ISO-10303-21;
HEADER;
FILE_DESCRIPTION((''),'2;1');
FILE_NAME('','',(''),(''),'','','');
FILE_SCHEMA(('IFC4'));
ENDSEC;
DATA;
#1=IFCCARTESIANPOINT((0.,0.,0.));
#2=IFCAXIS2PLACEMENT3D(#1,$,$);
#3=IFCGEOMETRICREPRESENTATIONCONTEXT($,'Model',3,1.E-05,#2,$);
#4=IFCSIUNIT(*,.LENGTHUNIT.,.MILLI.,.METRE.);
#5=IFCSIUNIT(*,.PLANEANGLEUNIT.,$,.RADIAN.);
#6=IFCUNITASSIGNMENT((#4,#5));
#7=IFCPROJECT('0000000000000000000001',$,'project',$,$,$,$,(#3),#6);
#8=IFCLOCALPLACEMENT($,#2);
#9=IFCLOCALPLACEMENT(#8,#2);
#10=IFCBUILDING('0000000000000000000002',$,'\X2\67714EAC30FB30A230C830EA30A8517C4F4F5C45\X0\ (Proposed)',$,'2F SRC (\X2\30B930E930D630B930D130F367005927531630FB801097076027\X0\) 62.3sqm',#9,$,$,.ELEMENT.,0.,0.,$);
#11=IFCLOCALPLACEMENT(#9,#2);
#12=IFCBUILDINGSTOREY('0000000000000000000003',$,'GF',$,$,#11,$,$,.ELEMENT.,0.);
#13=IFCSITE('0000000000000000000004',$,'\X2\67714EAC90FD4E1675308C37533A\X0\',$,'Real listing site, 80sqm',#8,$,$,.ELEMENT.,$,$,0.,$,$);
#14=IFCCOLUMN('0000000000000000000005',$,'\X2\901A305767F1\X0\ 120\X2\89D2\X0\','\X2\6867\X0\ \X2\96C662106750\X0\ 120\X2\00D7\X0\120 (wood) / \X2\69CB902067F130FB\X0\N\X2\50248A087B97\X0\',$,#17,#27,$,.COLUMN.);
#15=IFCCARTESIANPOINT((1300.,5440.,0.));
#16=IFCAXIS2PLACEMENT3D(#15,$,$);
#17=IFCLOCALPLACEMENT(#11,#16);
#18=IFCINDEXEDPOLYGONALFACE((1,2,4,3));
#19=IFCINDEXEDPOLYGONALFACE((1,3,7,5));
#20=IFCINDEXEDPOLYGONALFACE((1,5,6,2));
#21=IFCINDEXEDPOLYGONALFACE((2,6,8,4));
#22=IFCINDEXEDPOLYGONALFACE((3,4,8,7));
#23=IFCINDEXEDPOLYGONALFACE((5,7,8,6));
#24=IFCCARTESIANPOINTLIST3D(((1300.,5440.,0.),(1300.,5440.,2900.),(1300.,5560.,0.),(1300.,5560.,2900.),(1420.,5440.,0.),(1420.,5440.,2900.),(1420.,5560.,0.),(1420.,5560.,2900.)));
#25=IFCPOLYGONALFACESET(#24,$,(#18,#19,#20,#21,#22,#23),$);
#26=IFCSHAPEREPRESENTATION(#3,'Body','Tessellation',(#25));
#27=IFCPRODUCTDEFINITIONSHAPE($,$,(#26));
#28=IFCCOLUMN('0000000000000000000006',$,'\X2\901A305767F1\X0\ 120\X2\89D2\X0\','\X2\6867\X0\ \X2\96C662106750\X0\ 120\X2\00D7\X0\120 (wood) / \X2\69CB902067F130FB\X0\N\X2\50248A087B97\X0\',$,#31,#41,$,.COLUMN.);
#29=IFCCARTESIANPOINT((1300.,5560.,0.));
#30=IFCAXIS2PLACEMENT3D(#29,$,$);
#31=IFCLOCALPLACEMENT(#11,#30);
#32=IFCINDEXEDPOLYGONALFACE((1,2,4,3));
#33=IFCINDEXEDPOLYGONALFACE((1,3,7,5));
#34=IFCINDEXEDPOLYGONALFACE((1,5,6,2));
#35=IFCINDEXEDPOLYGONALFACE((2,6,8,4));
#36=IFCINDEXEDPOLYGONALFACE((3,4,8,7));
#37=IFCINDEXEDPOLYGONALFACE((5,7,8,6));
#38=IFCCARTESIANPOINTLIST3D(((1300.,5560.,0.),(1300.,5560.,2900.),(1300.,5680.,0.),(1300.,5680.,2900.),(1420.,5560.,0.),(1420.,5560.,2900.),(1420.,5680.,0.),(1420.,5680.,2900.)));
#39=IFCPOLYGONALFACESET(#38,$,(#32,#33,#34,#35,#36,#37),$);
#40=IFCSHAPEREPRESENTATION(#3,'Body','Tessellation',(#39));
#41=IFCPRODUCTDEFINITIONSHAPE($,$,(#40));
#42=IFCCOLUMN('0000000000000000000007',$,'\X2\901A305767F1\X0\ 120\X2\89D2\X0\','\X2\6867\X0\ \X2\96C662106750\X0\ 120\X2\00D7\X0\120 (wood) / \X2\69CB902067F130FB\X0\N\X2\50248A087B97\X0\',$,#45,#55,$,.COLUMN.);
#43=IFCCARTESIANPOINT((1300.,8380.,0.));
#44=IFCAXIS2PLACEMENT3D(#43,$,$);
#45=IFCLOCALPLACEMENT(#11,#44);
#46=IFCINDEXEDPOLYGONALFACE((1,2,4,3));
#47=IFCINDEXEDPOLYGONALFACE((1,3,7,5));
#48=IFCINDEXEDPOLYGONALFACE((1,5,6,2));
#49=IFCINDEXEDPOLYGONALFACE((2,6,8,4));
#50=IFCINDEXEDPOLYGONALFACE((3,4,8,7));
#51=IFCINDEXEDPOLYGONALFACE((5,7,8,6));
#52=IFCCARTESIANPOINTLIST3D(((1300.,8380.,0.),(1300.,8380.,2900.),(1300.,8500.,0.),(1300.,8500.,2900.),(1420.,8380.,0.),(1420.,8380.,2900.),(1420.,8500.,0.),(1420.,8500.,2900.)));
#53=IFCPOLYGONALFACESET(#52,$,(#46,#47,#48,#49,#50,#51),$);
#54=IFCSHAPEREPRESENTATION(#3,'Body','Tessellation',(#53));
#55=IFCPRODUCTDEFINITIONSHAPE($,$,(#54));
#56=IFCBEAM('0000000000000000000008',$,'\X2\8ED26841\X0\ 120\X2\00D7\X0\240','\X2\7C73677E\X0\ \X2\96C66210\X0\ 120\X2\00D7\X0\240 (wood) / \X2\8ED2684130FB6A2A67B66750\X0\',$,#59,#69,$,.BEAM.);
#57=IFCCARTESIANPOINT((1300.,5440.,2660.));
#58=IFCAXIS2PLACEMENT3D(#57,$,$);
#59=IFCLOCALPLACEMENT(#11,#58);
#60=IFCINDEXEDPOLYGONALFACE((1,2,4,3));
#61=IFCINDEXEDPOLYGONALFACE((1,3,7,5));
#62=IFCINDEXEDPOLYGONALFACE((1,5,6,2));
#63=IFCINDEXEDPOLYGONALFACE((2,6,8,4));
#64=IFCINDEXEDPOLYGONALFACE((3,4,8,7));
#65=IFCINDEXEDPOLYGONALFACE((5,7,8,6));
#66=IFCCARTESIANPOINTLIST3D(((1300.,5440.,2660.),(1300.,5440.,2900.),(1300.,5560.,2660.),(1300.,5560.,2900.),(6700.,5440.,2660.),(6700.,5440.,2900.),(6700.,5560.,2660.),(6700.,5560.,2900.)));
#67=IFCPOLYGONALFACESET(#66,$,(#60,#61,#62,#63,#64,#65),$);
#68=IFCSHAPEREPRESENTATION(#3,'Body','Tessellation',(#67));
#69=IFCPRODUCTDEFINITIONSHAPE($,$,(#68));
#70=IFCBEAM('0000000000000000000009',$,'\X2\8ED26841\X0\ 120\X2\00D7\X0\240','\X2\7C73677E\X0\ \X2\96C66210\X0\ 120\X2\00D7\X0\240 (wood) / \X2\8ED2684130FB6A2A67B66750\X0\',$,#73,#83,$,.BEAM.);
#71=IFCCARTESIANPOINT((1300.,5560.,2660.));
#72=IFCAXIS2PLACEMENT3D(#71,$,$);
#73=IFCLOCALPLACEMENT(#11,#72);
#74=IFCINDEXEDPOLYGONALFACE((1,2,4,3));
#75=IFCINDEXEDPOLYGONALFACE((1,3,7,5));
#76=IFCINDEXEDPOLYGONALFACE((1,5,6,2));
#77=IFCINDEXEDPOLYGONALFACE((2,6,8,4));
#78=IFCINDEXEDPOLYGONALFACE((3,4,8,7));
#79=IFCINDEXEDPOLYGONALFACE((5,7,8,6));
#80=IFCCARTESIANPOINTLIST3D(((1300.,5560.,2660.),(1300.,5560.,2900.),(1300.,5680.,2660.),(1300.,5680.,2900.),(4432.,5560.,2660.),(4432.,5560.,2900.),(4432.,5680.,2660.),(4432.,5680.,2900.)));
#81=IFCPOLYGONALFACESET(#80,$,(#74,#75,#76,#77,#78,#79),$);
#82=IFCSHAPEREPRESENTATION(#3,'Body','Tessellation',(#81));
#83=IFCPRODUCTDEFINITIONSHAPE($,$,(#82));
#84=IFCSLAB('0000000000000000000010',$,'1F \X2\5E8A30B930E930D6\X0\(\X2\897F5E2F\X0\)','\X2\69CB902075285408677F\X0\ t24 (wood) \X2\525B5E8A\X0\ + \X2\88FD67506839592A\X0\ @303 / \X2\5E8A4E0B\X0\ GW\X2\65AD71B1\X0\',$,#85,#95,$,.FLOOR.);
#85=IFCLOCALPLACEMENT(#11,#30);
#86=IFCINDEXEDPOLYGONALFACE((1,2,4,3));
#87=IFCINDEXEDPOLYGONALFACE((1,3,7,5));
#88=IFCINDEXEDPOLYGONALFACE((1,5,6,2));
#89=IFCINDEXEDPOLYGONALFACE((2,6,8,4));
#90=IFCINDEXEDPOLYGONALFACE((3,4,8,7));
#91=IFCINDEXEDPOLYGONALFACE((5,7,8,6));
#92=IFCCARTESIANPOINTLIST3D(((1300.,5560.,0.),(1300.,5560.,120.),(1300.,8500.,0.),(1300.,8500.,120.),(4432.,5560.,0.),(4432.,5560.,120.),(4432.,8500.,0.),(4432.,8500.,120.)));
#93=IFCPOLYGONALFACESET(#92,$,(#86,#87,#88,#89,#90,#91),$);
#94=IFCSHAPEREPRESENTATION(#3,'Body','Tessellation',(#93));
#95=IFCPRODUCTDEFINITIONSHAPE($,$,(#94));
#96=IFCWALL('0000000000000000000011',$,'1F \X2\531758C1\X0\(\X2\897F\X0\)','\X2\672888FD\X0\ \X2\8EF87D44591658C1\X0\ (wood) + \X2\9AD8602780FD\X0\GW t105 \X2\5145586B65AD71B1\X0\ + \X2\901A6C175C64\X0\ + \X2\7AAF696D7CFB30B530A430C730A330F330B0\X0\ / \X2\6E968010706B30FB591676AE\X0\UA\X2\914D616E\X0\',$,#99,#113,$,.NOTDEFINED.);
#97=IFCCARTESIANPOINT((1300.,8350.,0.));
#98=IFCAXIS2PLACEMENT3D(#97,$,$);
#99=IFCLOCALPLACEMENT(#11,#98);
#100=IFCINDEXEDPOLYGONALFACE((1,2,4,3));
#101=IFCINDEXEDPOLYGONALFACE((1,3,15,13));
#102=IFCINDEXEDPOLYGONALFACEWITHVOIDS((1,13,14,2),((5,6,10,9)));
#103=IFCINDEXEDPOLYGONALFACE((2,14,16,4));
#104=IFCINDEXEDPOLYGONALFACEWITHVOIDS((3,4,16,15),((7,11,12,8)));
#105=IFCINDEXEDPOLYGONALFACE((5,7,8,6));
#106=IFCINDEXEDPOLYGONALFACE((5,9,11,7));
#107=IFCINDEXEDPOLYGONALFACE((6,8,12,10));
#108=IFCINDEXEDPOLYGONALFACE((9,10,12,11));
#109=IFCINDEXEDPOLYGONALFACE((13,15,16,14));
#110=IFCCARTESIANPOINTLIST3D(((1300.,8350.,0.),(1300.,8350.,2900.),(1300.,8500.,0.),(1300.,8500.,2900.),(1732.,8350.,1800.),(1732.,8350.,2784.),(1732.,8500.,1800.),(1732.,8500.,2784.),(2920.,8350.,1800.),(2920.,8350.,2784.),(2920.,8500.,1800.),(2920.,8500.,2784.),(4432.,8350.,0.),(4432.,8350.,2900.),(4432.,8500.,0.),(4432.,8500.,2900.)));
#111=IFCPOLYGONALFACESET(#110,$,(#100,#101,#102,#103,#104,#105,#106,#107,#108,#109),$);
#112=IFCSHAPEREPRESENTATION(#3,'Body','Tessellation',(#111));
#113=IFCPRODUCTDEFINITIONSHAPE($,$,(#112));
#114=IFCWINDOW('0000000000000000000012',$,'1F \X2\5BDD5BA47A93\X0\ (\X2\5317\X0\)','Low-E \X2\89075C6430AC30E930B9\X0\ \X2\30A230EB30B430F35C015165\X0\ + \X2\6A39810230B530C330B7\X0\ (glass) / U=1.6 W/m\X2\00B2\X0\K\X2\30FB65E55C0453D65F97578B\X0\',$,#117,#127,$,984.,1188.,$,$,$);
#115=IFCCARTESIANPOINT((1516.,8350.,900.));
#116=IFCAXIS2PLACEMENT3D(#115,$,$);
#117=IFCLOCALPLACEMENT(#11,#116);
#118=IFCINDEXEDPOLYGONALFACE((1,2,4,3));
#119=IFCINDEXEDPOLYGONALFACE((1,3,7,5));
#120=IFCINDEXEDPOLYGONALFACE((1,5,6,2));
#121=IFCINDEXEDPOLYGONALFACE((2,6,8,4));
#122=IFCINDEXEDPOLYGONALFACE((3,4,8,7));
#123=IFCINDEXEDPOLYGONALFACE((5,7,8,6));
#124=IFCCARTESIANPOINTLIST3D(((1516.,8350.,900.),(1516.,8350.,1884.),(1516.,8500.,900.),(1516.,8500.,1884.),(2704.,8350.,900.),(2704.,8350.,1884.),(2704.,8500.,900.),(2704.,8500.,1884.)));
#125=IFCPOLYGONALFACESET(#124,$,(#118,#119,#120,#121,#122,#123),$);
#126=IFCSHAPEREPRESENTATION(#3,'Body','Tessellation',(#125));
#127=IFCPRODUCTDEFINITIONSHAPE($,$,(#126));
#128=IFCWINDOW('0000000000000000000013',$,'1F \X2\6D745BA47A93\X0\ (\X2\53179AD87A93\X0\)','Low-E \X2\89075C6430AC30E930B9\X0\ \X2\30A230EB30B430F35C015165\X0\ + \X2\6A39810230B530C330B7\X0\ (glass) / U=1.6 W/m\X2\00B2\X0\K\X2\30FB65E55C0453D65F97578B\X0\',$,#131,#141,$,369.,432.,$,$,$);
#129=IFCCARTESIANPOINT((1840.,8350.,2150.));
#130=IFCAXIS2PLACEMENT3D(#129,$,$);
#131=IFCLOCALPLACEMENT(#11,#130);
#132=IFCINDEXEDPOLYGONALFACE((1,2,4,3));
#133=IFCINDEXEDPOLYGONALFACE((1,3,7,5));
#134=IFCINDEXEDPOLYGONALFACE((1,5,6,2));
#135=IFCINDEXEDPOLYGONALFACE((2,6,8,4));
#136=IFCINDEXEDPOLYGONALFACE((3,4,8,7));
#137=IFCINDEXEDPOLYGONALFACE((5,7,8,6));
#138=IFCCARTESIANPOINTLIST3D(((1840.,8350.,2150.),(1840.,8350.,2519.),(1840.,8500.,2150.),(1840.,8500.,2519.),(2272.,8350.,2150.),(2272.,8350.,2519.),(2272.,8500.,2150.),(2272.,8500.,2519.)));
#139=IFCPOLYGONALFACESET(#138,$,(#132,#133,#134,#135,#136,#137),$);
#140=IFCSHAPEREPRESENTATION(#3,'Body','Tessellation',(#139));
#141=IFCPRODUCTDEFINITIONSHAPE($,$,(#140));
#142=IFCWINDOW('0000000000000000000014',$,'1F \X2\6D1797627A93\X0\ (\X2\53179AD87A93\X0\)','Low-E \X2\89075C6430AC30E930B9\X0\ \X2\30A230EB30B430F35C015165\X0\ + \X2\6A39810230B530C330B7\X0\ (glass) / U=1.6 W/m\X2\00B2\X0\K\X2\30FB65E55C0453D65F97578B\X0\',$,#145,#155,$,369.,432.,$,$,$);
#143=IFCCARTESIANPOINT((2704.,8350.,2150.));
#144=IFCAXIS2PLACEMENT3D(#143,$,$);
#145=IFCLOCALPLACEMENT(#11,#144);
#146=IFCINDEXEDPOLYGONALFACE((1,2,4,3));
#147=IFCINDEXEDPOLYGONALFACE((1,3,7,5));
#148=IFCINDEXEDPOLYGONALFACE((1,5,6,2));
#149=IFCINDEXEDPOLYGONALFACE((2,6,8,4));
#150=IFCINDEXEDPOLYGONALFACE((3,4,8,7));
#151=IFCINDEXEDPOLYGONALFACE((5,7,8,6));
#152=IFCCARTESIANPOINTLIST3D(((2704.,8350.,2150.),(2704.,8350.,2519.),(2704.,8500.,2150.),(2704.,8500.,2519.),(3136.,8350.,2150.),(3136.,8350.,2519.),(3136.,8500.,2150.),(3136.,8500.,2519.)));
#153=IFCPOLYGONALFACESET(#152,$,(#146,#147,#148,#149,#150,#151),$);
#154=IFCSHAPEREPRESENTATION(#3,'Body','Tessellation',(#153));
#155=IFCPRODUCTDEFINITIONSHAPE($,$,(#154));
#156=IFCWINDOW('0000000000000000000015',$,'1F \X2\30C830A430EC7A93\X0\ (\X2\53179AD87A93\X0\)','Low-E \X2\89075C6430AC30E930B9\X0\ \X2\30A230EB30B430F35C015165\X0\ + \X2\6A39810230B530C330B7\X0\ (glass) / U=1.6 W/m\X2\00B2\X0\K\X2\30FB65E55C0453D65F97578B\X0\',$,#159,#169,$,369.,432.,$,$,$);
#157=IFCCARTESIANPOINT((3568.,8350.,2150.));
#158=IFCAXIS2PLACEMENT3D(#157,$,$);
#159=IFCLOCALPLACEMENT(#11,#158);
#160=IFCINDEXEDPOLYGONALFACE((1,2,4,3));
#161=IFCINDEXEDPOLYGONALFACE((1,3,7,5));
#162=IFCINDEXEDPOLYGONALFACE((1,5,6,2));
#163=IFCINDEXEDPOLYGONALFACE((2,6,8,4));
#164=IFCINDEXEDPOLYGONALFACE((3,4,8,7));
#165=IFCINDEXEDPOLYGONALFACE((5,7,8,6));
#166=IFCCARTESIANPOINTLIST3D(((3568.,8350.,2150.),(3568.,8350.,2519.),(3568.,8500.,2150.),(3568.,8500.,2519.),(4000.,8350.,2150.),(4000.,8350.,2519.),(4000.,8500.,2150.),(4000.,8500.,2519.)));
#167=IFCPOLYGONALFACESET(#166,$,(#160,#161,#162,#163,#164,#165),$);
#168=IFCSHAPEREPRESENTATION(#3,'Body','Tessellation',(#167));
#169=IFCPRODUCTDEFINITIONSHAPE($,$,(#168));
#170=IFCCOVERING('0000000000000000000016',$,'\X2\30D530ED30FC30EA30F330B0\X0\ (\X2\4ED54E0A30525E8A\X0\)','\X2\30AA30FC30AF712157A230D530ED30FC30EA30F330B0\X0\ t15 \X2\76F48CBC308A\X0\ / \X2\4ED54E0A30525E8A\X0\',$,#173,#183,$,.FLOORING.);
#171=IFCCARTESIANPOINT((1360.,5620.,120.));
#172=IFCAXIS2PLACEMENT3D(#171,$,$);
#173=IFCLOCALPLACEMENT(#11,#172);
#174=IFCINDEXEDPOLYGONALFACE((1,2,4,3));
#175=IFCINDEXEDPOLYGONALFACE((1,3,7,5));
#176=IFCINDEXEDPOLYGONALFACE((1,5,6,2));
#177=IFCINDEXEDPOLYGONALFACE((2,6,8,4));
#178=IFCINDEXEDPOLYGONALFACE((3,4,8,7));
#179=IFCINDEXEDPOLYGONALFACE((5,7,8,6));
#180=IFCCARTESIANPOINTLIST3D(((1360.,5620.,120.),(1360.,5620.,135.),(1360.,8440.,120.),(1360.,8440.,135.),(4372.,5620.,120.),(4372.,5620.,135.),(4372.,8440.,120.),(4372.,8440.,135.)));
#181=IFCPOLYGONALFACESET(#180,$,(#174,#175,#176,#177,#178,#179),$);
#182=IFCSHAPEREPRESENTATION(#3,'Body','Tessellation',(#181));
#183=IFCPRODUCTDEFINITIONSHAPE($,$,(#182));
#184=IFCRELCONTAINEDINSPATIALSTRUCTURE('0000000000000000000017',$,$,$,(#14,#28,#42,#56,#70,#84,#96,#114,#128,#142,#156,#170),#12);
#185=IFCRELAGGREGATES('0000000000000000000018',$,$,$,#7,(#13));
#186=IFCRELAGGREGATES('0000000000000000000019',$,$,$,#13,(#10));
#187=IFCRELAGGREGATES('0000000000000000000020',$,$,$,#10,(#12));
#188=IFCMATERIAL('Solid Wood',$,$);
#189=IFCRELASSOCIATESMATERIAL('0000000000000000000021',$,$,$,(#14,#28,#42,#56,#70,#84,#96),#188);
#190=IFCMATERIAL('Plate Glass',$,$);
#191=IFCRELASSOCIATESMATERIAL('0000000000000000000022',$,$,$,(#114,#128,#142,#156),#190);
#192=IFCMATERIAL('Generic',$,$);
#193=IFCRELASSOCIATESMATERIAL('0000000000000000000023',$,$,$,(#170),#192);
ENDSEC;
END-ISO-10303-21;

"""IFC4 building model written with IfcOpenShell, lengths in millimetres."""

from ifc_helpers import new_model, si_unit, frame, frame_2d, origin, place, context, project, spatial, rectangle, extrude, material, element, fill, save


model = new_model("IFC4")

# Units and contexts
model_context = context("Model", 3, precision=1e-05, world=origin())
ifc_project = project(units=[si_unit("LENGTHUNIT", "METRE", prefix="MILLI"), si_unit("PLANEANGLEUNIT", "RADIAN")], contexts=[model_context])

# Site, building, storey
site_placement = place(None, origin())
site = spatial("IfcSite", under=ifc_project, at=site_placement, Name="東京都世田谷区", ObjectType="Real listing site, 80sqm", CompositionType="ELEMENT", RefElevation=0.0)
building_placement = place(site_placement, origin())
building = spatial("IfcBuilding", under=site, at=building_placement, Name="東京・アトリエ兼住居 (Proposed)", ObjectType="2F SRC (スラブスパン最大化・耐震性) 62.3sqm", CompositionType="ELEMENT", ElevationOfRefHeight=0.0, ElevationOfTerrain=0.0)
storey_placement = place(building_placement, origin())
storey = spatial("IfcBuildingStorey", under=building, at=storey_placement, Name="GF", CompositionType="ELEMENT", Elevation=0.0)

# Columns
ifc_material_1 = material(Name="Solid Wood")
column_1_placement = place(storey_placement, frame((1300.0, 5440.0, 0.0)))
element("IfcColumn", 1, at=column_1_placement, inside=storey, material=ifc_material_1, Name="通し柱 120角", Description="桧 集成材 120×120 (wood) / 構造柱・N値計算", PredefinedType="COLUMN", context=model_context, shape_type="SweptSolid", body=[
    extrude(rectangle(XDim=120.0, YDim=120.0, at=frame_2d((60.0, 60.0))), frame((1300.0, 5440.0, 0.0)), (0.0, 0.0, 1.0), 2900.0),
])
column_2_placement = place(storey_placement, frame((1300.0, 5560.0, 0.0)))
element("IfcColumn", 2, at=column_2_placement, inside=storey, material=ifc_material_1, Name="通し柱 120角", Description="桧 集成材 120×120 (wood) / 構造柱・N値計算", PredefinedType="COLUMN", context=model_context, shape_type="SweptSolid", body=[
    extrude(rectangle(XDim=120.0, YDim=120.0, at=frame_2d((60.0, 60.0))), frame((1300.0, 5560.0, 0.0)), (0.0, 0.0, 1.0), 2900.0),
])
column_3_placement = place(storey_placement, frame((1300.0, 8380.0, 0.0)))
element("IfcColumn", 3, at=column_3_placement, inside=storey, material=ifc_material_1, Name="通し柱 120角", Description="桧 集成材 120×120 (wood) / 構造柱・N値計算", PredefinedType="COLUMN", context=model_context, shape_type="SweptSolid", body=[
    extrude(rectangle(XDim=120.0, YDim=120.0, at=frame_2d((60.0, 60.0))), frame((1300.0, 8380.0, 0.0)), (0.0, 0.0, 1.0), 2900.0),
])

# Beams
beam_1_placement = place(storey_placement, frame((1300.0, 5440.0, 2660.0)))
element("IfcBeam", 4, at=beam_1_placement, inside=storey, material=ifc_material_1, Name="軒桁 120×240", Description="米松 集成 120×240 (wood) / 軒桁・横架材", PredefinedType="BEAM", context=model_context, shape_type="SweptSolid", body=[
    extrude(rectangle(XDim=5400.0, YDim=120.0, at=frame_2d((2700.0, 60.0))), frame((1300.0, 5440.0, 2660.0)), (0.0, 0.0, 1.0), 240.0),
])
beam_2_placement = place(storey_placement, frame((1300.0, 5560.0, 2660.0)))
element("IfcBeam", 5, at=beam_2_placement, inside=storey, material=ifc_material_1, Name="軒桁 120×240", Description="米松 集成 120×240 (wood) / 軒桁・横架材", PredefinedType="BEAM", context=model_context, shape_type="SweptSolid", body=[
    extrude(rectangle(XDim=3132.0, YDim=120.0, at=frame_2d((1566.0, 60.0))), frame((1300.0, 5560.0, 2660.0)), (0.0, 0.0, 1.0), 240.0),
])

# Slab
slab_placement = place(storey_placement, frame((1300.0, 5560.0, 0.0)))
element("IfcSlab", 6, at=slab_placement, inside=storey, material=ifc_material_1, Name="1F 床スラブ(西帯)", Description="構造用合板 t24 (wood) 剛床 + 製材根太 @303 / 床下 GW断熱", PredefinedType="FLOOR", context=model_context, shape_type="SweptSolid", body=[
    extrude(rectangle(XDim=3132.0, YDim=2940.0, at=frame_2d((1566.0, 1470.0))), frame((1300.0, 5560.0, 0.0)), (0.0, 0.0, 1.0), 120.0),
])

# Wall, openings, windows
wall_1_placement = place(storey_placement, frame((1300.0, 8350.0, 0.0)))
wall_1 = element("IfcWall", 7, at=wall_1_placement, inside=storey, material=ifc_material_1, Name="1F 北壁(西)", Description="木製 軸組外壁 (wood) + 高性能GW t105 充填断熱 + 通気層 + 窯業系サイディング / 準耐火・外皮UA配慮", PredefinedType="NOTDEFINED", context=model_context, shape_type="SweptSolid", body=[
    extrude(rectangle(XDim=3132.0, YDim=150.0, at=frame_2d((1566.0, 75.0))), frame((1300.0, 8350.0, 0.0)), (0.0, 0.0, 1.0), 2900.0),
])
opening_1_placement = place(storey_placement, frame((1516.0, 8350.0, 900.0)))
opening_1 = element("IfcOpeningElement", 8, at=opening_1_placement, cuts=wall_1, PredefinedType="NOTDEFINED", context=model_context, shape_type="SweptSolid", body=[
    extrude(rectangle(XDim=1188.0, YDim=150.0, at=frame_2d((594.0, 75.0))), frame((1516.0, 8350.0, 900.0)), (0.0, 0.0, 1.0), 984.0),
])
opening_2_placement = place(storey_placement, frame((1840.0, 8350.0, 2150.0)))
opening_2 = element("IfcOpeningElement", 9, at=opening_2_placement, cuts=wall_1, PredefinedType="NOTDEFINED", context=model_context, shape_type="SweptSolid", body=[
    extrude(rectangle(XDim=432.0, YDim=150.0, at=frame_2d((216.0, 75.0))), frame((1840.0, 8350.0, 2150.0)), (0.0, 0.0, 1.0), 369.0),
])
opening_3_placement = place(storey_placement, frame((2704.0, 8350.0, 2150.0)))
opening_3 = element("IfcOpeningElement", 10, at=opening_3_placement, cuts=wall_1, PredefinedType="NOTDEFINED", context=model_context, shape_type="SweptSolid", body=[
    extrude(rectangle(XDim=432.0, YDim=150.0, at=frame_2d((216.0, 75.0))), frame((2704.0, 8350.0, 2150.0)), (0.0, 0.0, 1.0), 369.0),
])
opening_4_placement = place(storey_placement, frame((3568.0, 8350.0, 2150.0)))
opening_4 = element("IfcOpeningElement", 11, at=opening_4_placement, cuts=wall_1, PredefinedType="NOTDEFINED", context=model_context, shape_type="SweptSolid", body=[
    extrude(rectangle(XDim=432.0, YDim=150.0, at=frame_2d((216.0, 75.0))), frame((3568.0, 8350.0, 2150.0)), (0.0, 0.0, 1.0), 369.0),
])
ifc_material_2 = material(Name="Plate Glass")
window_1_placement = place(storey_placement, frame((1516.0, 8350.0, 900.0)))
window_1 = element("IfcWindow", 12, at=window_1_placement, inside=storey, material=ifc_material_2, Name="1F 寝室窓 (北)", Description="Low-E 複層ガラス アルゴン封入 + 樹脂サッシ (glass) / U=1.6 W/m²K・日射取得型", OverallHeight=984.0, OverallWidth=1188.0, context=model_context, shape_type="SweptSolid", body=[
    extrude(rectangle(XDim=1188.0, YDim=150.0, at=frame_2d((594.0, 75.0))), frame((1516.0, 8350.0, 900.0)), (0.0, 0.0, 1.0), 984.0),
])
fill(opening_1, window_1)
window_2_placement = place(storey_placement, frame((1840.0, 8350.0, 2150.0)))
window_2 = element("IfcWindow", 13, at=window_2_placement, inside=storey, material=ifc_material_2, Name="1F 浴室窓 (北高窓)", Description="Low-E 複層ガラス アルゴン封入 + 樹脂サッシ (glass) / U=1.6 W/m²K・日射取得型", OverallHeight=369.0, OverallWidth=432.0, context=model_context, shape_type="SweptSolid", body=[
    extrude(rectangle(XDim=432.0, YDim=150.0, at=frame_2d((216.0, 75.0))), frame((1840.0, 8350.0, 2150.0)), (0.0, 0.0, 1.0), 369.0),
])
fill(opening_2, window_2)
window_3_placement = place(storey_placement, frame((2704.0, 8350.0, 2150.0)))
window_3 = element("IfcWindow", 14, at=window_3_placement, inside=storey, material=ifc_material_2, Name="1F 洗面窓 (北高窓)", Description="Low-E 複層ガラス アルゴン封入 + 樹脂サッシ (glass) / U=1.6 W/m²K・日射取得型", OverallHeight=369.0, OverallWidth=432.0, context=model_context, shape_type="SweptSolid", body=[
    extrude(rectangle(XDim=432.0, YDim=150.0, at=frame_2d((216.0, 75.0))), frame((2704.0, 8350.0, 2150.0)), (0.0, 0.0, 1.0), 369.0),
])
fill(opening_3, window_3)
window_4_placement = place(storey_placement, frame((3568.0, 8350.0, 2150.0)))
window_4 = element("IfcWindow", 15, at=window_4_placement, inside=storey, material=ifc_material_2, Name="1F トイレ窓 (北高窓)", Description="Low-E 複層ガラス アルゴン封入 + 樹脂サッシ (glass) / U=1.6 W/m²K・日射取得型", OverallHeight=369.0, OverallWidth=432.0, context=model_context, shape_type="SweptSolid", body=[
    extrude(rectangle(XDim=432.0, YDim=150.0, at=frame_2d((216.0, 75.0))), frame((3568.0, 8350.0, 2150.0)), (0.0, 0.0, 1.0), 369.0),
])
fill(opening_4, window_4)

# Covering
ifc_material_3 = material(Name="Generic")
covering_placement = place(storey_placement, frame((1360.0, 5620.0, 120.0)))
element("IfcCovering", 16, at=covering_placement, inside=storey, material=ifc_material_3, Name="フローリング (仕上げ床)", Description="オーク無垢フローリング t15 直貼り / 仕上げ床", PredefinedType="FLOORING", context=model_context, shape_type="SweptSolid", body=[
    extrude(rectangle(XDim=3012.0, YDim=2820.0, at=frame_2d((1506.0, 1410.0))), frame((1360.0, 5620.0, 120.0)), (0.0, 0.0, 1.0), 15.0),
])

save(model, "model.ifc")
